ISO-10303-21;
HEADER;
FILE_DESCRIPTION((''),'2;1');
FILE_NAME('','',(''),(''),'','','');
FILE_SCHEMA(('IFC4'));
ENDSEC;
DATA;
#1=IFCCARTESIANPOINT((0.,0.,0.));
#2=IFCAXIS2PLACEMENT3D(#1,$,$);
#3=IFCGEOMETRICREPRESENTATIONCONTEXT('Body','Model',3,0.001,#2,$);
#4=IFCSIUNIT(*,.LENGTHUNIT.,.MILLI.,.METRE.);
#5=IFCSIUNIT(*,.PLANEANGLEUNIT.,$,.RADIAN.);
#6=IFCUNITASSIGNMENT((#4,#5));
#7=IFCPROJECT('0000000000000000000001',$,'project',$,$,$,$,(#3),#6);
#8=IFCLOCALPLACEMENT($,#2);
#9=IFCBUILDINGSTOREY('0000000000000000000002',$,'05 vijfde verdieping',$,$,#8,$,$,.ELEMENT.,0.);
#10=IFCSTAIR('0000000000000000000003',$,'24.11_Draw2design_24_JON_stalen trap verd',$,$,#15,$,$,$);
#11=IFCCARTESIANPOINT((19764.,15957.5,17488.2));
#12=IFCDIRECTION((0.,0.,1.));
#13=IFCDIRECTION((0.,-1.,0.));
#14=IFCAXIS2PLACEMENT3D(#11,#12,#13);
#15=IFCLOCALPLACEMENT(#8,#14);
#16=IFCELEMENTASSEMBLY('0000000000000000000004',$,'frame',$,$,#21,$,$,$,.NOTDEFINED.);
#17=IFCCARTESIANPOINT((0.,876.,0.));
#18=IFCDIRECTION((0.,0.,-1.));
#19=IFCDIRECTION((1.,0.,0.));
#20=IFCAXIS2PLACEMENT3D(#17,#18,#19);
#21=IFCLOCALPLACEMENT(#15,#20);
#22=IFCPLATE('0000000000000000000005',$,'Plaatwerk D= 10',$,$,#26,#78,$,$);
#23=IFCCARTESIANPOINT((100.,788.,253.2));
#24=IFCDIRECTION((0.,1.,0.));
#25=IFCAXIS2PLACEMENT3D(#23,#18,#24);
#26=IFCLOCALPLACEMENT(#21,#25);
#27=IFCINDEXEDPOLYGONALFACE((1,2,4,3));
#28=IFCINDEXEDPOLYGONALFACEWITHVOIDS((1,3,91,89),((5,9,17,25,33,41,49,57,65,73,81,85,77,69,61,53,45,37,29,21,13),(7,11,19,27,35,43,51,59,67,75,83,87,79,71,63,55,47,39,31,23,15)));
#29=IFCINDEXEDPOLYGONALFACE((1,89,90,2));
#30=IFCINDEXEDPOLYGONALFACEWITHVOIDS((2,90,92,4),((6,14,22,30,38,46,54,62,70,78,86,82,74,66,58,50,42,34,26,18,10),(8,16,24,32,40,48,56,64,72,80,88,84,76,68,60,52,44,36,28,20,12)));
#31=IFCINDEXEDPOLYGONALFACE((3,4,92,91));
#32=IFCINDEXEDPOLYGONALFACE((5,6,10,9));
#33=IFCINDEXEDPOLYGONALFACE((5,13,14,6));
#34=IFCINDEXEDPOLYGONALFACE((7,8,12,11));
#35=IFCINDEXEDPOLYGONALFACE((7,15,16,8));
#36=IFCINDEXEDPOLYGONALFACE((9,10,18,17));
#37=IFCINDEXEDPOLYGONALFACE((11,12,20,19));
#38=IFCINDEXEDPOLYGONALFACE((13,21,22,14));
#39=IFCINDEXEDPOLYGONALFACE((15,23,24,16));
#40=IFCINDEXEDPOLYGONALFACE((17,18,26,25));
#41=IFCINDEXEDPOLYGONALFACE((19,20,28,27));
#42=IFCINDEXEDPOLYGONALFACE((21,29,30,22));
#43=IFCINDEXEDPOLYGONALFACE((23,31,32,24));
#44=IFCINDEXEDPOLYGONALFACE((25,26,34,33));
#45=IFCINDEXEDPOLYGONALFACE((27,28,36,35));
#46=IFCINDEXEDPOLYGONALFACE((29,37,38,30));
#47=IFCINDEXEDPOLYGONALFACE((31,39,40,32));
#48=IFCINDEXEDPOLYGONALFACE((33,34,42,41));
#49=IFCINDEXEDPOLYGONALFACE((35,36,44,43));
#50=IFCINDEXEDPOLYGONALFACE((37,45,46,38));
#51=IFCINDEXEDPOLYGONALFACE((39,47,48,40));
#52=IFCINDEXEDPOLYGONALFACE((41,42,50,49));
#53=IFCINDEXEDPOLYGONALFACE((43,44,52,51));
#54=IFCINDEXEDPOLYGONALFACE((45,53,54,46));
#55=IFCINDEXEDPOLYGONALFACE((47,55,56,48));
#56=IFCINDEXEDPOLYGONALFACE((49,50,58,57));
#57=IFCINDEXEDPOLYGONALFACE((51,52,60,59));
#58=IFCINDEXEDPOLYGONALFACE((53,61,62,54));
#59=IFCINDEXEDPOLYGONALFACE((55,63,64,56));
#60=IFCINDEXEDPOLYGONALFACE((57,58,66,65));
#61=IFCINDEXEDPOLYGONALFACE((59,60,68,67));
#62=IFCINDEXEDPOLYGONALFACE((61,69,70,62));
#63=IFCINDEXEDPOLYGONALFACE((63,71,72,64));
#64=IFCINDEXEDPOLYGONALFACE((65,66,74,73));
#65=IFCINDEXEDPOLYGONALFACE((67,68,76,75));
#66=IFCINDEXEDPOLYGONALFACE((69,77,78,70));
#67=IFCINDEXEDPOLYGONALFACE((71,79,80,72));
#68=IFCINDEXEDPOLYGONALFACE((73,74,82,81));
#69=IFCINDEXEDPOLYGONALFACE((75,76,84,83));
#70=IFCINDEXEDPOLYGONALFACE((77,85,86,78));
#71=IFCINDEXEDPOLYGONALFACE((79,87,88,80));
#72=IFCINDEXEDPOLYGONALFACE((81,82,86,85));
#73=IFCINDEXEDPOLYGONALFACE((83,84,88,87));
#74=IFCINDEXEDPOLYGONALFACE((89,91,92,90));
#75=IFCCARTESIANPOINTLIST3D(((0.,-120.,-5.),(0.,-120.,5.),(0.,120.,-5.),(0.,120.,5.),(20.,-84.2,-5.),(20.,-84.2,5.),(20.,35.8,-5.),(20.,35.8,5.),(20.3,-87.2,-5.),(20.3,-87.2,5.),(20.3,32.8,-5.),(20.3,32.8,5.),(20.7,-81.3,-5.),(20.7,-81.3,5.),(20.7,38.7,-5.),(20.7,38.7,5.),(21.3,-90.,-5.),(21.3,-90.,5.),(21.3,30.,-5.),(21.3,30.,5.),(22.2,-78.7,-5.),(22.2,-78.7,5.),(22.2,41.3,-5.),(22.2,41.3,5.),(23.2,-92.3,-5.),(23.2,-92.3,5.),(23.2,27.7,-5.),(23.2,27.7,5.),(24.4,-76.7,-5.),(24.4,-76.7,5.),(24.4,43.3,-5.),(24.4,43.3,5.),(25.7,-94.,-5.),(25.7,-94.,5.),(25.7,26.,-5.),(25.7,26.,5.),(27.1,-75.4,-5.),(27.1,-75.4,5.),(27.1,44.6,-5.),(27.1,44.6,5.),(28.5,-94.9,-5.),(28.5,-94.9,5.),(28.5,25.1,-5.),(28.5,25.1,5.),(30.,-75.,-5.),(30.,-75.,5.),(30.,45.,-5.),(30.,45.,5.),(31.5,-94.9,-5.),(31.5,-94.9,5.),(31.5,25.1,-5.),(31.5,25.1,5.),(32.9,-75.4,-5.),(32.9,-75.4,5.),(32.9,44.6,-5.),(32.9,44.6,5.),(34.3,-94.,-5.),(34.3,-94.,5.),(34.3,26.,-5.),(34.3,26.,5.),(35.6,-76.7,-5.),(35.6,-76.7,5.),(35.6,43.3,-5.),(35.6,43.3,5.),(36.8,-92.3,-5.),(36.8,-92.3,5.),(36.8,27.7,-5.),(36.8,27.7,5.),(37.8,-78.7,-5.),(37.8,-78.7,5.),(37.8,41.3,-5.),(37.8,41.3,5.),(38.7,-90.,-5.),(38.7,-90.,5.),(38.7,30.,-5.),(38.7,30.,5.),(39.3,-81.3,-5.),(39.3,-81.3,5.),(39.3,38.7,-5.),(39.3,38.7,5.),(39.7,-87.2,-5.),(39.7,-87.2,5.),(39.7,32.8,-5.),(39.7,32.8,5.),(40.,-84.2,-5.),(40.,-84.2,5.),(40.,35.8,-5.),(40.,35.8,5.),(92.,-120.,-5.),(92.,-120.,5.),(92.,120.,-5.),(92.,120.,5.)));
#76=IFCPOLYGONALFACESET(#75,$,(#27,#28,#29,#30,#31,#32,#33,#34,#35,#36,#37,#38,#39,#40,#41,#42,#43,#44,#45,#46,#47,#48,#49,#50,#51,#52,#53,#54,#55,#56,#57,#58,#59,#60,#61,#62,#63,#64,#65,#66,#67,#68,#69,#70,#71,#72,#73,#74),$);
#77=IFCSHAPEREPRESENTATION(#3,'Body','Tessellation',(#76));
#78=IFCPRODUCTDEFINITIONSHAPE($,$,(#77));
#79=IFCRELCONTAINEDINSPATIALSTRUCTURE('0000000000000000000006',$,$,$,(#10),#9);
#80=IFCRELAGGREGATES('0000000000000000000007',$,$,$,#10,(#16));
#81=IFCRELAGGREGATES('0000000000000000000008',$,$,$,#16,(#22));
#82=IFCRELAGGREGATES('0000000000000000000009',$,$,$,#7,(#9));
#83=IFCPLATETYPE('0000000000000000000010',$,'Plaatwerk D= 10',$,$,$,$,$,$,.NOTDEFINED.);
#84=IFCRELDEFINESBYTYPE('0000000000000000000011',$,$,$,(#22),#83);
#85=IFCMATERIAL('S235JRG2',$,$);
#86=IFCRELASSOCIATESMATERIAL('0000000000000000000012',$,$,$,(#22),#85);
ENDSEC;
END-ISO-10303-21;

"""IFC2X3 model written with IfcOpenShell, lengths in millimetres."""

from ifc_helpers import new_model, si_unit, frame, origin, origin_2d, place, context, project, spatial, rectangle, circle, extrude, source, transform, mapped, material, type_object, element, aggregate, save


model = new_model("IFC2X3")

# Units and contexts
model_context = context("Model", 3, precision=0.001, world=origin(), identifier="Body")
ifc_project = project(units=[si_unit("LENGTHUNIT", "METRE", prefix="MILLI"), si_unit("PLANEANGLEUNIT", "RADIAN")], contexts=[model_context])

# Storey
storey_placement = place(None, origin())
storey = spatial("IfcBuildingStorey", under=ifc_project, at=storey_placement, Name="05 vijfde verdieping", CompositionType="ELEMENT", Elevation=0.0)

# Shared definitions
ifc_material_1 = material(Name="S235JRG2")

# Stair
stair_placement = place(storey_placement, frame((19764.0, 15957.5, 17488.2), z_axis=(0.0, 0.0, 1.0), x_axis=(0.0, -1.0, 0.0)))
stair = element("IfcStair", 1, at=stair_placement, inside=storey, Name="24.11_Draw2design_24_JON_stalen trap verd")

# Element assembly
assembly_placement = place(stair_placement, frame((0.0, 876.0, 0.0), z_axis=(0.0, 0.0, -1.0), x_axis=(1.0, 0.0, 0.0)))
assembly = element("IfcElementAssembly", 2, at=assembly_placement, Name="frame", PredefinedType="NOTDEFINED")
aggregate(stair, [assembly])

# Plate, openings
plate_type = type_object("IfcPlateType", Name="Plaatwerk D= 10")
shared_shape_1 = source(origin(), model_context, "Body", "SweptSolid", [
    extrude(rectangle(XDim=92.0, YDim=240.0, at=origin_2d()), frame((46.0, 0.0, -5.0)), (0.0, 0.0, 1.0), 10.0),
])
plate_1_placement = place(assembly_placement, frame((100.0, 788.0, 253.2), z_axis=(0.0, 0.0, -1.0), x_axis=(0.0, 1.0, 0.0)))
plate_1 = element("IfcPlate", 3, at=plate_1_placement, type_object=plate_type, material=ifc_material_1, Name="Plaatwerk D= 10", context=model_context, shape_type="MappedRepresentation", body=[
    mapped(shared_shape_1, transform((0.0, 0.0, 0.0), scale=1.0)),
])
opening_1_placement = place(plate_1_placement, frame((30.0, -85.0, 5.0), z_axis=(0.0, 0.0, -1.0), x_axis=(0.0, 1.0, 0.0)))
element("IfcOpeningElement", 4, at=opening_1_placement, cuts=plate_1, ObjectType="Opening", context=model_context, shape_type="SweptSolid", body=[
    extrude(circle(Radius=10.0, at=origin_2d()), origin(), (0.0, 0.0, 1.0), 10.0),
])
opening_2_placement = place(plate_1_placement, frame((30.0, 35.0, 5.0), z_axis=(0.0, 0.0, -1.0), x_axis=(0.0, 1.0, 0.0)))
element("IfcOpeningElement", 5, at=opening_2_placement, cuts=plate_1, ObjectType="Opening", context=model_context, shape_type="SweptSolid", body=[
    extrude(circle(Radius=10.0, at=origin_2d()), origin(), (0.0, 0.0, 1.0), 10.0),
])
aggregate(assembly, [plate_1])

save(model, "model.ifc")
